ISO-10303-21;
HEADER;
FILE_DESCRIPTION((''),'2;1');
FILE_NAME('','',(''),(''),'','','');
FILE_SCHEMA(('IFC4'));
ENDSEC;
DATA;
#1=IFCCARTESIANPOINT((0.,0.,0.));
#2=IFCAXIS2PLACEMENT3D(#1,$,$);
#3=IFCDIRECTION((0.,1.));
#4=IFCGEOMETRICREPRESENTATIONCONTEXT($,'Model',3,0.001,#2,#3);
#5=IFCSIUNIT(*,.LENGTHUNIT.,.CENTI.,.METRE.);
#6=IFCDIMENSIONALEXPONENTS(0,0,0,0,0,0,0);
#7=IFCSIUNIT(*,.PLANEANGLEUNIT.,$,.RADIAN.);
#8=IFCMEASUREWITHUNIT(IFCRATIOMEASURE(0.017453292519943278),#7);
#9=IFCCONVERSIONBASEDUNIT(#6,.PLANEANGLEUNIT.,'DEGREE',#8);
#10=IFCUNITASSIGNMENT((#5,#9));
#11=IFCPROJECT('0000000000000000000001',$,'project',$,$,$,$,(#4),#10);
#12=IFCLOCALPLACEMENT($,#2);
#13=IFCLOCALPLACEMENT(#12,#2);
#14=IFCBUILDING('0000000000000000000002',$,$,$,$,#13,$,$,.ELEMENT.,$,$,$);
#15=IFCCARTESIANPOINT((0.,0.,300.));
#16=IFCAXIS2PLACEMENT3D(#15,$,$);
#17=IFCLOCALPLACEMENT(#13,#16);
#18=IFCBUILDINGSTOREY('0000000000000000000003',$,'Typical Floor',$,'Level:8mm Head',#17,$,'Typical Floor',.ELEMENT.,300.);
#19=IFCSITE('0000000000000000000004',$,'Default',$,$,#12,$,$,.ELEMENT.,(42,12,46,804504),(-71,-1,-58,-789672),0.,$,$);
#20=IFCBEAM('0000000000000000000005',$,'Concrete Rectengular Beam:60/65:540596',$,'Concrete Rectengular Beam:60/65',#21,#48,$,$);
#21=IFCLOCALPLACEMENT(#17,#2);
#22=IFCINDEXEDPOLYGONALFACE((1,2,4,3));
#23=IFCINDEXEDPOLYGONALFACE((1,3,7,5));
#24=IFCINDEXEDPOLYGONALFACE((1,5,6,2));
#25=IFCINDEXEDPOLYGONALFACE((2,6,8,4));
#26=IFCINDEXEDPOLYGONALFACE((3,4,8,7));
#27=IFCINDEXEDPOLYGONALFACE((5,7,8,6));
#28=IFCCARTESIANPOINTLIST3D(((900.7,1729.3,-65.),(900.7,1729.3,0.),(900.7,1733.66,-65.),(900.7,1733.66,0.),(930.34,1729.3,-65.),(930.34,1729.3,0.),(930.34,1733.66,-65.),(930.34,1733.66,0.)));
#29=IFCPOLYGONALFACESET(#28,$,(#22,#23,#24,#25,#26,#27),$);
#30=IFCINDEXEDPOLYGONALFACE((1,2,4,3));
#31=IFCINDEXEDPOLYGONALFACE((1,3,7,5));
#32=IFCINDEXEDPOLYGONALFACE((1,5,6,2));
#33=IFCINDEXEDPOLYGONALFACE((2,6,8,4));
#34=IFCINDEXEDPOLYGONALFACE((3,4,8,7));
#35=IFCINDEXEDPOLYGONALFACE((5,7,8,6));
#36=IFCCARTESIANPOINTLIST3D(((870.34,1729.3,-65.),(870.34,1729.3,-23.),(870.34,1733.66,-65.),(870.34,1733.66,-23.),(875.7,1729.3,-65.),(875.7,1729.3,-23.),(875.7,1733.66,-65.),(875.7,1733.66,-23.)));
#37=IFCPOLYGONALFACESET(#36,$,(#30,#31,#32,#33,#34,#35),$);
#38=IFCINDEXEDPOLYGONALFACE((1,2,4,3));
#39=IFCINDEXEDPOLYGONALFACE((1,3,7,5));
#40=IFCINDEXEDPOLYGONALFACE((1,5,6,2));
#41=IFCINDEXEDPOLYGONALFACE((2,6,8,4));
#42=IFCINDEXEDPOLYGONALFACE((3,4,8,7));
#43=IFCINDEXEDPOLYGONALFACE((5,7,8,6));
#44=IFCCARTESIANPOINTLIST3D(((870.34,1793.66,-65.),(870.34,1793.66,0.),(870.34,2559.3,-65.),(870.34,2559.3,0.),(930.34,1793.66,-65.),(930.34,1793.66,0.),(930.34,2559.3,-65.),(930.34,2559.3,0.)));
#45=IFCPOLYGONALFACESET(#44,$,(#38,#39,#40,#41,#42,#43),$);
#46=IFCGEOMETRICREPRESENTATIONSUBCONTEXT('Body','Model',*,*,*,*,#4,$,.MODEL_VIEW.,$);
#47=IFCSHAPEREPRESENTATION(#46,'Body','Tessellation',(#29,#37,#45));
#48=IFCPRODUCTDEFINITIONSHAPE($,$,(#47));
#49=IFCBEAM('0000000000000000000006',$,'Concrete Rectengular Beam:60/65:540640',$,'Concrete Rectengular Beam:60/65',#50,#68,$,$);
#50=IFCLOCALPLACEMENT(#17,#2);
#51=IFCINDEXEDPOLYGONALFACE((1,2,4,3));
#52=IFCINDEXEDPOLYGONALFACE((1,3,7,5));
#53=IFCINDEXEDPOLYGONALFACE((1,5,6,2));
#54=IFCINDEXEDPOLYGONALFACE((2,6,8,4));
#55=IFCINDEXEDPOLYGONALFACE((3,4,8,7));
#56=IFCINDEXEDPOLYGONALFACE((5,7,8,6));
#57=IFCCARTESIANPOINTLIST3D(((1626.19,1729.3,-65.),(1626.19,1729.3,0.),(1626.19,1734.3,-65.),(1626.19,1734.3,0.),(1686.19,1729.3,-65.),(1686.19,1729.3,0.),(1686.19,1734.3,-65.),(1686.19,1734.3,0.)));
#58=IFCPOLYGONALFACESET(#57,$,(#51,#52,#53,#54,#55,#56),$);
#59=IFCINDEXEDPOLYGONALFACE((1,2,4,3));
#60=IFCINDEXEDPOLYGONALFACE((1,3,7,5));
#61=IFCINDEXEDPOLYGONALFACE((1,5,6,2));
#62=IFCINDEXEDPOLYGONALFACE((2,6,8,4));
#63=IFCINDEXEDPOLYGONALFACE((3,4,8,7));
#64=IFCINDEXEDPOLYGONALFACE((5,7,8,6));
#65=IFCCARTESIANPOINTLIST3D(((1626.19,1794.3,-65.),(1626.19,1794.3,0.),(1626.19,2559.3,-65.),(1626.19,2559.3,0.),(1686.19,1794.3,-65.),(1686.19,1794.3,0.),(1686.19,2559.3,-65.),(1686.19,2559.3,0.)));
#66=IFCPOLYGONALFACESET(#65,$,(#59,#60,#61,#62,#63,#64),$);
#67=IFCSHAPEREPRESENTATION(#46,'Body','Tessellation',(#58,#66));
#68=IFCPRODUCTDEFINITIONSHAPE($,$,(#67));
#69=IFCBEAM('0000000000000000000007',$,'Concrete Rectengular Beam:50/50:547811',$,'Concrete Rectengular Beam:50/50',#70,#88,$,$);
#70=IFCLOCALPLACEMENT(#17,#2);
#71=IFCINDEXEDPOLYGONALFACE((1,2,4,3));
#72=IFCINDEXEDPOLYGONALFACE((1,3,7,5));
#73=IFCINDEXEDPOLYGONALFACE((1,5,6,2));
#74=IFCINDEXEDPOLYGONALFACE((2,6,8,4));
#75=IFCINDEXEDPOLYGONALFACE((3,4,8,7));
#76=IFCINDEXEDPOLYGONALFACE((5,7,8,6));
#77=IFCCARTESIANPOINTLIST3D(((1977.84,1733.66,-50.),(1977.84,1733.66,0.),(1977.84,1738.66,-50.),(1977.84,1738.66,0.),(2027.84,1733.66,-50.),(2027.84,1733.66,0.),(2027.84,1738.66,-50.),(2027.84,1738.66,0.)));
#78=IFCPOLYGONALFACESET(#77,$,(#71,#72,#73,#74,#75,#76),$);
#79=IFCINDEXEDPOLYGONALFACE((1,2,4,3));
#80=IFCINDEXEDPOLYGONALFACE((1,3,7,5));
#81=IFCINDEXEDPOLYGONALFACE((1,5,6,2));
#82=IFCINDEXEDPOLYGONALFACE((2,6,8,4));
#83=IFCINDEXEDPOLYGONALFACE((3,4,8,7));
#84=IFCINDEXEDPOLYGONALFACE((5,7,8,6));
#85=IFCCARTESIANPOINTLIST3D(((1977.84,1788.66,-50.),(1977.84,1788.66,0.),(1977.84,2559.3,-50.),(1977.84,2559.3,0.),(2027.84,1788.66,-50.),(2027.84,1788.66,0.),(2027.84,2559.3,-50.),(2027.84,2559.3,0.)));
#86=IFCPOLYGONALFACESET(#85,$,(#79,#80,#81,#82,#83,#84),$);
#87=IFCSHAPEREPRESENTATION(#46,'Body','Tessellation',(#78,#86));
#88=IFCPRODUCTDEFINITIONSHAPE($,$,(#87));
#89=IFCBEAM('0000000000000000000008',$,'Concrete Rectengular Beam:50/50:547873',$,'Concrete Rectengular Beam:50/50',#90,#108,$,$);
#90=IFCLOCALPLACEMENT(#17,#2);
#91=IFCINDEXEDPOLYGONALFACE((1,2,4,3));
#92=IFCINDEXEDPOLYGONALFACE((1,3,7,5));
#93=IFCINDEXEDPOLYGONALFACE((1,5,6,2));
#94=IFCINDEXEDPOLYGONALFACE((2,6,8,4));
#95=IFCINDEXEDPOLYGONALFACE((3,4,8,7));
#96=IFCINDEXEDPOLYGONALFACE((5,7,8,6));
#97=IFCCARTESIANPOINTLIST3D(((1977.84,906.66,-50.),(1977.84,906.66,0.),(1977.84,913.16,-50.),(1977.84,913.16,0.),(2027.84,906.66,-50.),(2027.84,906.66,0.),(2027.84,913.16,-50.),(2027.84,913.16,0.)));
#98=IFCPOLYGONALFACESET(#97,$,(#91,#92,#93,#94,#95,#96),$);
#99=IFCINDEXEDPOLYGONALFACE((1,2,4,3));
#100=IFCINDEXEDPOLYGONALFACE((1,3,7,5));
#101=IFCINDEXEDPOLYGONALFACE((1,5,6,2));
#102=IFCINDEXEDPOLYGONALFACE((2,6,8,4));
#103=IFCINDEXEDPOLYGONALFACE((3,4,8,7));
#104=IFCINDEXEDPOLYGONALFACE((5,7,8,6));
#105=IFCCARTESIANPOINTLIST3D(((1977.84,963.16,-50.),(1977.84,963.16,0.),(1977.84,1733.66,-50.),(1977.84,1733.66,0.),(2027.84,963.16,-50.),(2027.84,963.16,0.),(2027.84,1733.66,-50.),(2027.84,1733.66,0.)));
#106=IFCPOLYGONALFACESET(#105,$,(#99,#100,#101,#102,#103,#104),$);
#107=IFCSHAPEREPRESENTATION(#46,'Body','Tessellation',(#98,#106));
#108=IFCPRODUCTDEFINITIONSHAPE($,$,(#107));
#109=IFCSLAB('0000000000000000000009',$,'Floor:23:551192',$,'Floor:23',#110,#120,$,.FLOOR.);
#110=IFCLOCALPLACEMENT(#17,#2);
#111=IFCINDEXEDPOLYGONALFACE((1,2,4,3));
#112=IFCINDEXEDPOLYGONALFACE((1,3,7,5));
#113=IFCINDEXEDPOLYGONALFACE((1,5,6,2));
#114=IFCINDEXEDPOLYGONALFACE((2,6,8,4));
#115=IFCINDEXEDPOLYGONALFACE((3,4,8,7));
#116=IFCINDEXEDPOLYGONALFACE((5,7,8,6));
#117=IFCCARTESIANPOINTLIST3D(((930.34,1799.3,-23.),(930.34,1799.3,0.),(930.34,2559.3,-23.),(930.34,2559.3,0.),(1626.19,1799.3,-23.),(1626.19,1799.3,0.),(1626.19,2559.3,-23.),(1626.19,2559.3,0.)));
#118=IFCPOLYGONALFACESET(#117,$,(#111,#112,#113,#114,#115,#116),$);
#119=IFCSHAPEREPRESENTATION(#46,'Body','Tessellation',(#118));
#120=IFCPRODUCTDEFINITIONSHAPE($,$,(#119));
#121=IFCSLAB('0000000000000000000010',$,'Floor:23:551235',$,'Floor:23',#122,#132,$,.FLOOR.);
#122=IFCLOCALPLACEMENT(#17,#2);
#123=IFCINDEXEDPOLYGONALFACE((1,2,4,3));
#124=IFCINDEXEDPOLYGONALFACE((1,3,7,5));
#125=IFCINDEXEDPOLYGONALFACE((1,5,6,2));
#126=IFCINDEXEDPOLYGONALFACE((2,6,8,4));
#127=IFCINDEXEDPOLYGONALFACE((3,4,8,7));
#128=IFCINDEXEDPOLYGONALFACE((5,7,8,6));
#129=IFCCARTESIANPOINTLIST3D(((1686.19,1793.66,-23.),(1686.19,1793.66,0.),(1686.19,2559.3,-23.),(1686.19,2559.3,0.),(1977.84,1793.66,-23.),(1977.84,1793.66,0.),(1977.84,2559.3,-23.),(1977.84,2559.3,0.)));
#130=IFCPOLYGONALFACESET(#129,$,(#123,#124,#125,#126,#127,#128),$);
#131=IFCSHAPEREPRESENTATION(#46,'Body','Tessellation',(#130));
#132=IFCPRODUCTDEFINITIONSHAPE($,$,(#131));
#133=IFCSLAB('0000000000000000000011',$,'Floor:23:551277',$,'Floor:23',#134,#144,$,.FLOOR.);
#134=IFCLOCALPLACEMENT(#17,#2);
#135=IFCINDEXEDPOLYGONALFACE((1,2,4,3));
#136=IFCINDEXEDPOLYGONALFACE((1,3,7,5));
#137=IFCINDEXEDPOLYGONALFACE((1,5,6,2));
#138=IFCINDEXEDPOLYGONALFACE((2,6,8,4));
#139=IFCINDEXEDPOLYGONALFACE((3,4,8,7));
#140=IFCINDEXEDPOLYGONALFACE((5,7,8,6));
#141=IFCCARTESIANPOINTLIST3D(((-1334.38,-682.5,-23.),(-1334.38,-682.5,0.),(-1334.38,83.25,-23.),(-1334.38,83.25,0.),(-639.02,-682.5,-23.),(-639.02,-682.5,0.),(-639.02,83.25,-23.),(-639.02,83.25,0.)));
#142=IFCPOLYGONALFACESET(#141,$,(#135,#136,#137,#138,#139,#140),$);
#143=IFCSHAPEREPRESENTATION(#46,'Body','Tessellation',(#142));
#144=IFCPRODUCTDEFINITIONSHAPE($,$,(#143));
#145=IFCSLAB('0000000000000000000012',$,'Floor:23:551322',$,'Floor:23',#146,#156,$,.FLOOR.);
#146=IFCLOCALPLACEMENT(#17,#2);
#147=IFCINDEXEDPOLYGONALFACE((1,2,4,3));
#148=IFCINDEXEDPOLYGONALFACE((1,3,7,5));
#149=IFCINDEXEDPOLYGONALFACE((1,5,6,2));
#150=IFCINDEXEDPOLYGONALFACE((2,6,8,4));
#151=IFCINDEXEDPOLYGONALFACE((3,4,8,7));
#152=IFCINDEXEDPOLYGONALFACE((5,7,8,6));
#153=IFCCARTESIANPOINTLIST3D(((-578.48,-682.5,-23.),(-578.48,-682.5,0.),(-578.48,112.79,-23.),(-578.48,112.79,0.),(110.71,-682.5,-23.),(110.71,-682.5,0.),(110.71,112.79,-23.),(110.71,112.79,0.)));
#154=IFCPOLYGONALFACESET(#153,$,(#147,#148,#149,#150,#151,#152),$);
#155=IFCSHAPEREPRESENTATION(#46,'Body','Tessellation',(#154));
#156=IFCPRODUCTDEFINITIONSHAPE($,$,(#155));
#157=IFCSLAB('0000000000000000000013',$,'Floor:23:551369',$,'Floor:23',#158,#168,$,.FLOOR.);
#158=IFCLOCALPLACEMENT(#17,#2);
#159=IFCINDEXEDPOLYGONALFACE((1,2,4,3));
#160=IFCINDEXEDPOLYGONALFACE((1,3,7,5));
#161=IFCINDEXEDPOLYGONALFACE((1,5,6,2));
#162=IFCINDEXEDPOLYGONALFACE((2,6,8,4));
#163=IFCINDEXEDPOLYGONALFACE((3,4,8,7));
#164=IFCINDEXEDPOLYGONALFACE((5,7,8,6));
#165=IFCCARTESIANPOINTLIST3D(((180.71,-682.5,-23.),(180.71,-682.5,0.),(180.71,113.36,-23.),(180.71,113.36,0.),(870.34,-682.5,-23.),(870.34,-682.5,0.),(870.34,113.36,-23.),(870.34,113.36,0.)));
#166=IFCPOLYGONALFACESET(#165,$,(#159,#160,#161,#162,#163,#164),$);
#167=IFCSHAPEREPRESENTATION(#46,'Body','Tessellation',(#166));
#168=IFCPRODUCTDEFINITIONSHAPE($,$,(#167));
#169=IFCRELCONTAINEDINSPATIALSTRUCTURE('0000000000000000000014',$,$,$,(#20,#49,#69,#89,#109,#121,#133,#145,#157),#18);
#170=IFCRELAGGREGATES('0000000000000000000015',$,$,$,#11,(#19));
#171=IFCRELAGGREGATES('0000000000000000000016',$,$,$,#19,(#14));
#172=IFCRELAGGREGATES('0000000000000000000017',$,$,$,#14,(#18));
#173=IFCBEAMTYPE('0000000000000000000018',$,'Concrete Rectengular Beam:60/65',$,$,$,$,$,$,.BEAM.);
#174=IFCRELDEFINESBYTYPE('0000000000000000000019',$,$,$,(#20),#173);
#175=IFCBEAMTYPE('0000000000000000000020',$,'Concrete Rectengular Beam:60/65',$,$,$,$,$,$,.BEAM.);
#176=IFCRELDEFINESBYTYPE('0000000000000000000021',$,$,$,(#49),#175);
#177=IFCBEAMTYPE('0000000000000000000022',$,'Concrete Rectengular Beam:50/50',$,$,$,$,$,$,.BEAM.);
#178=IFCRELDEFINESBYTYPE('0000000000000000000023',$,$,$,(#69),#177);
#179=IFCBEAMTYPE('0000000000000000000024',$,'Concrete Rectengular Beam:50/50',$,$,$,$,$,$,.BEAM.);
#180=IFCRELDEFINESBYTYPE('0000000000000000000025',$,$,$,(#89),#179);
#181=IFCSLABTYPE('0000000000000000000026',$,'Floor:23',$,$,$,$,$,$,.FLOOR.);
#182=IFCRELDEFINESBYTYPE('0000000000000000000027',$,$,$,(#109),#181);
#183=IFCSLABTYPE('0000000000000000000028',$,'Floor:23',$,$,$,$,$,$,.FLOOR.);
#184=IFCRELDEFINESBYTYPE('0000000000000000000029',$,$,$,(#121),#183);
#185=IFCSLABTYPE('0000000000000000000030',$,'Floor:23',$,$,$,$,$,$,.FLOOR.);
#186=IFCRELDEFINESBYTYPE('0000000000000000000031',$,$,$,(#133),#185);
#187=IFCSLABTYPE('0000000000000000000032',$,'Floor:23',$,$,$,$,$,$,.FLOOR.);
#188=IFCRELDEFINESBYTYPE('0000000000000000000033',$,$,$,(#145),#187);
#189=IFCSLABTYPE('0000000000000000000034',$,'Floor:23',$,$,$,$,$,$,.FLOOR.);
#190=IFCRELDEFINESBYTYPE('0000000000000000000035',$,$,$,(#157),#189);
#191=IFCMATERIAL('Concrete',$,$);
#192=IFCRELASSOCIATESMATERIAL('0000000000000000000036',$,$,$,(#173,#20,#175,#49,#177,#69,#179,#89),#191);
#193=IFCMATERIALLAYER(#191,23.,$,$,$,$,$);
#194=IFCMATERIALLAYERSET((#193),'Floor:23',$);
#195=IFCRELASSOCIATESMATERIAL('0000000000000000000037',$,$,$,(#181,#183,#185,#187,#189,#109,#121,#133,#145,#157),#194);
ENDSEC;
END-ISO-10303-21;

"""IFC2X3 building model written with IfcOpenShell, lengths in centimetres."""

from ifc_helpers import new_model, entity, si_unit, converted_unit, direction, frame, frame_2d, origin, origin_2d_with_axis, place, context, subcontext, project, spatial, rectangle, extrude, source, transform, mapped, material, layer, layer_set, layer_usage, type_object, type_shapes, element, save


model = new_model("IFC2X3")

# Units and contexts
model_context = context("Model", 3, precision=0.001, world=origin(), true_north=direction((0.0, 1.0)))
body_context = subcontext(model_context, "Body", "Model", "MODEL_VIEW")
ifc_project = project(units=[si_unit("LENGTHUNIT", "METRE", prefix="CENTI"), converted_unit("PLANEANGLEUNIT", "DEGREE", entity("IfcRatioMeasure", 0.017453292519943278), si_unit("PLANEANGLEUNIT", "RADIAN"), dimensions=[0, 0, 0, 0, 0, 0, 0])], contexts=[model_context])

# Site, building, storey
site_placement = place(None, origin())
site = spatial("IfcSite", under=ifc_project, at=site_placement, Name="Default", CompositionType="ELEMENT", RefLatitude=(42, 12, 46, 804504), RefLongitude=(-71, -1, -58, -789672), RefElevation=0.0)
building_placement = place(site_placement, origin())
building = spatial("IfcBuilding", under=site, at=building_placement, CompositionType="ELEMENT")
storey_placement = place(building_placement, frame((0.0, 0.0, 300.0)))
storey = spatial("IfcBuildingStorey", under=building, at=storey_placement, Name="Typical Floor", ObjectType="Level:8mm Head", LongName="Typical Floor", CompositionType="ELEMENT", Elevation=300.0)

# Beams
ifc_material = material(Name="Concrete")
beam_type_1 = type_object("IfcBeamType", Name="Concrete Rectengular Beam:60/65", PredefinedType="BEAM", material=ifc_material)
shared_shape_1 = source(origin(), body_context, "Body", "SweptSolid", [
    extrude(rectangle(XDim=65.0, YDim=29.64, at=frame_2d((0.0, 0.0), x_axis=(0.0, 1.0))), frame((915.52, 1733.66, 267.5), z_axis=(0.0, -1.0, 0.0), x_axis=(-1.0, 0.0, 0.0)), (0.0, 0.0, 1.0), 4.36),
    extrude(rectangle(XDim=42.0, YDim=5.36, at=frame_2d((0.0, 0.0), x_axis=(0.0, 1.0))), frame((873.02, 1733.66, 256.0), z_axis=(0.0, -1.0, 0.0), x_axis=(-1.0, 0.0, 0.0)), (0.0, 0.0, 1.0), 4.36),
    extrude(rectangle(XDim=65.0, YDim=60.0, at=frame_2d((0.0, 0.0), x_axis=(0.0, 1.0))), frame((900.34, 2559.3, 267.5), z_axis=(0.0, -1.0, 0.0), x_axis=(-1.0, 0.0, 0.0)), (0.0, 0.0, 1.0), 765.63),
])
type_shapes(beam_type_1, [shared_shape_1])
beam_1_placement = place(storey_placement, frame((0.0, 0.0, -300.0)))
element("IfcBeam", 1, at=beam_1_placement, inside=storey, type_object=beam_type_1, material=ifc_material, Name="Concrete Rectengular Beam:60/65:540596", ObjectType="Concrete Rectengular Beam:60/65", context=body_context, shape_type="MappedRepresentation", body=[
    mapped(shared_shape_1, transform((0.0, 0.0, 0.0), scale=1.0)),
])
beam_type_2 = type_object("IfcBeamType", Name="Concrete Rectengular Beam:60/65", PredefinedType="BEAM", material=ifc_material)
shared_shape_2 = source(origin(), body_context, "Body", "SweptSolid", [
    extrude(rectangle(XDim=65.0, YDim=60.0, at=frame_2d((0.0, 0.0), x_axis=(0.0, 1.0))), frame((1656.19, 1734.3, 267.5), z_axis=(0.0, -1.0, 0.0), x_axis=(-1.0, 0.0, 0.0)), (0.0, 0.0, 1.0), 5.0),
    extrude(rectangle(XDim=65.0, YDim=60.0, at=frame_2d((0.0, 0.0), x_axis=(0.0, 1.0))), frame((1656.19, 2559.3, 267.5), z_axis=(0.0, -1.0, 0.0), x_axis=(-1.0, 0.0, 0.0)), (0.0, 0.0, 1.0), 764.99),
])
type_shapes(beam_type_2, [shared_shape_2])
beam_2_placement = place(storey_placement, frame((0.0, 0.0, -300.0)))
element("IfcBeam", 2, at=beam_2_placement, inside=storey, type_object=beam_type_2, material=ifc_material, Name="Concrete Rectengular Beam:60/65:540640", ObjectType="Concrete Rectengular Beam:60/65", context=body_context, shape_type="MappedRepresentation", body=[
    mapped(shared_shape_2, transform((0.0, 0.0, 0.0), scale=1.0)),
])
beam_type_3 = type_object("IfcBeamType", Name="Concrete Rectengular Beam:50/50", PredefinedType="BEAM", material=ifc_material)
shared_shape_3 = source(origin(), body_context, "Body", "SweptSolid", [
    extrude(rectangle(XDim=50.0, YDim=50.0, at=frame_2d((0.0, 0.0), x_axis=(0.0, 1.0))), frame((2002.84, 1738.66, 275.0), z_axis=(0.0, -1.0, 0.0), x_axis=(-1.0, 0.0, 0.0)), (0.0, 0.0, 1.0), 5.0),
    extrude(rectangle(XDim=50.0, YDim=50.0, at=frame_2d((0.0, 0.0), x_axis=(0.0, 1.0))), frame((2002.84, 2559.3, 275.0), z_axis=(0.0, -1.0, 0.0), x_axis=(-1.0, 0.0, 0.0)), (0.0, 0.0, 1.0), 770.63),
])
type_shapes(beam_type_3, [shared_shape_3])
beam_3_placement = place(storey_placement, frame((0.0, 0.0, -300.0)))
element("IfcBeam", 3, at=beam_3_placement, inside=storey, type_object=beam_type_3, material=ifc_material, Name="Concrete Rectengular Beam:50/50:547811", ObjectType="Concrete Rectengular Beam:50/50", context=body_context, shape_type="MappedRepresentation", body=[
    mapped(shared_shape_3, transform((0.0, 0.0, 0.0), scale=1.0)),
])
beam_type_4 = type_object("IfcBeamType", Name="Concrete Rectengular Beam:50/50", PredefinedType="BEAM", material=ifc_material)
shared_shape_4 = source(origin(), body_context, "Body", "SweptSolid", [
    extrude(rectangle(XDim=50.0, YDim=50.0, at=frame_2d((0.0, 0.0), x_axis=(0.0, 1.0))), frame((2002.84, 913.16, 275.0), z_axis=(0.0, -1.0, 0.0), x_axis=(-1.0, 0.0, 0.0)), (0.0, 0.0, 1.0), 6.5),
    extrude(rectangle(XDim=50.0, YDim=50.0, at=frame_2d((0.0, 0.0), x_axis=(0.0, 1.0))), frame((2002.84, 1733.66, 275.0), z_axis=(0.0, -1.0, 0.0), x_axis=(-1.0, 0.0, 0.0)), (0.0, 0.0, 1.0), 770.5),
])
type_shapes(beam_type_4, [shared_shape_4])
beam_4_placement = place(storey_placement, frame((0.0, 0.0, -300.0)))
element("IfcBeam", 4, at=beam_4_placement, inside=storey, type_object=beam_type_4, material=ifc_material, Name="Concrete Rectengular Beam:50/50:547873", ObjectType="Concrete Rectengular Beam:50/50", context=body_context, shape_type="MappedRepresentation", body=[
    mapped(shared_shape_4, transform((0.0, 0.0, 0.0), scale=1.0)),
])

# Slabs
ifc_layer = layer(ifc_material, 23.0)
ifc_layer_set = layer_set([ifc_layer], Name="Floor:23")
ifc_layer_usage_1 = layer_usage(ifc_layer_set, "AXIS3", "POSITIVE", 0.0)
slab_type_1 = type_object("IfcSlabType", Name="Floor:23", PredefinedType="FLOOR", material=ifc_layer_set)
slab_1_placement = place(storey_placement, origin())
element("IfcSlab", 5, at=slab_1_placement, inside=storey, type_object=slab_type_1, material=ifc_layer_usage_1, Name="Floor:23:551192", ObjectType="Floor:23", PredefinedType="FLOOR", context=body_context, shape_type="SweptSolid", body=[
    extrude(rectangle(XDim=759.99, YDim=695.85, at=origin_2d_with_axis()), frame((1278.26, 2179.3, 0.0), z_axis=(0.0, 0.0, -1.0), x_axis=(0.0, 1.0, 0.0)), (0.0, 0.0, 1.0), 23.0),
])
ifc_layer_usage_2 = layer_usage(ifc_layer_set, "AXIS3", "POSITIVE", 0.0)
slab_type_2 = type_object("IfcSlabType", Name="Floor:23", PredefinedType="FLOOR", material=ifc_layer_set)
slab_2_placement = place(storey_placement, origin())
element("IfcSlab", 6, at=slab_2_placement, inside=storey, type_object=slab_type_2, material=ifc_layer_usage_2, Name="Floor:23:551235", ObjectType="Floor:23", PredefinedType="FLOOR", context=body_context, shape_type="SweptSolid", body=[
    extrude(rectangle(XDim=765.63, YDim=291.65, at=frame_2d((0.0, 0.0), x_axis=(1.0, 0.0))), frame((1832.01, 2176.48, 0.0), z_axis=(0.0, 0.0, -1.0), x_axis=(0.0, 1.0, 0.0)), (0.0, 0.0, 1.0), 23.0),
])
ifc_layer_usage_3 = layer_usage(ifc_layer_set, "AXIS3", "POSITIVE", 0.0)
slab_type_3 = type_object("IfcSlabType", Name="Floor:23", PredefinedType="FLOOR", material=ifc_layer_set)
slab_3_placement = place(storey_placement, origin())
element("IfcSlab", 7, at=slab_3_placement, inside=storey, type_object=slab_type_3, material=ifc_layer_usage_3, Name="Floor:23:551277", ObjectType="Floor:23", PredefinedType="FLOOR", context=body_context, shape_type="SweptSolid", body=[
    extrude(rectangle(XDim=765.75, YDim=695.37, at=frame_2d((0.0, 0.0), x_axis=(1.0, 0.0))), frame((-986.7, -299.63, 0.0), z_axis=(0.0, 0.0, -1.0), x_axis=(0.0, 1.0, 0.0)), (0.0, 0.0, 1.0), 23.0),
])
ifc_layer_usage_4 = layer_usage(ifc_layer_set, "AXIS3", "POSITIVE", 0.0)
slab_type_4 = type_object("IfcSlabType", Name="Floor:23", PredefinedType="FLOOR", material=ifc_layer_set)
slab_4_placement = place(storey_placement, origin())
element("IfcSlab", 8, at=slab_4_placement, inside=storey, type_object=slab_type_4, material=ifc_layer_usage_4, Name="Floor:23:551322", ObjectType="Floor:23", PredefinedType="FLOOR", context=body_context, shape_type="SweptSolid", body=[
    extrude(rectangle(XDim=795.29, YDim=689.19, at=frame_2d((0.0, 0.0), x_axis=(1.0, 0.0))), frame((-233.89, -284.85, 0.0), z_axis=(0.0, 0.0, -1.0), x_axis=(0.0, 1.0, 0.0)), (0.0, 0.0, 1.0), 23.0),
])
ifc_layer_usage_5 = layer_usage(ifc_layer_set, "AXIS3", "POSITIVE", 0.0)
slab_type_5 = type_object("IfcSlabType", Name="Floor:23", PredefinedType="FLOOR", material=ifc_layer_set)
slab_5_placement = place(storey_placement, origin())
element("IfcSlab", 9, at=slab_5_placement, inside=storey, type_object=slab_type_5, material=ifc_layer_usage_5, Name="Floor:23:551369", ObjectType="Floor:23", PredefinedType="FLOOR", context=body_context, shape_type="SweptSolid", body=[
    extrude(rectangle(XDim=795.86, YDim=689.63, at=frame_2d((0.0, 0.0), x_axis=(1.0, 0.0))), frame((525.52, -284.57, 0.0), z_axis=(0.0, 0.0, -1.0), x_axis=(0.0, 1.0, 0.0)), (0.0, 0.0, 1.0), 23.0),
])

save(model, "model.ifc")
